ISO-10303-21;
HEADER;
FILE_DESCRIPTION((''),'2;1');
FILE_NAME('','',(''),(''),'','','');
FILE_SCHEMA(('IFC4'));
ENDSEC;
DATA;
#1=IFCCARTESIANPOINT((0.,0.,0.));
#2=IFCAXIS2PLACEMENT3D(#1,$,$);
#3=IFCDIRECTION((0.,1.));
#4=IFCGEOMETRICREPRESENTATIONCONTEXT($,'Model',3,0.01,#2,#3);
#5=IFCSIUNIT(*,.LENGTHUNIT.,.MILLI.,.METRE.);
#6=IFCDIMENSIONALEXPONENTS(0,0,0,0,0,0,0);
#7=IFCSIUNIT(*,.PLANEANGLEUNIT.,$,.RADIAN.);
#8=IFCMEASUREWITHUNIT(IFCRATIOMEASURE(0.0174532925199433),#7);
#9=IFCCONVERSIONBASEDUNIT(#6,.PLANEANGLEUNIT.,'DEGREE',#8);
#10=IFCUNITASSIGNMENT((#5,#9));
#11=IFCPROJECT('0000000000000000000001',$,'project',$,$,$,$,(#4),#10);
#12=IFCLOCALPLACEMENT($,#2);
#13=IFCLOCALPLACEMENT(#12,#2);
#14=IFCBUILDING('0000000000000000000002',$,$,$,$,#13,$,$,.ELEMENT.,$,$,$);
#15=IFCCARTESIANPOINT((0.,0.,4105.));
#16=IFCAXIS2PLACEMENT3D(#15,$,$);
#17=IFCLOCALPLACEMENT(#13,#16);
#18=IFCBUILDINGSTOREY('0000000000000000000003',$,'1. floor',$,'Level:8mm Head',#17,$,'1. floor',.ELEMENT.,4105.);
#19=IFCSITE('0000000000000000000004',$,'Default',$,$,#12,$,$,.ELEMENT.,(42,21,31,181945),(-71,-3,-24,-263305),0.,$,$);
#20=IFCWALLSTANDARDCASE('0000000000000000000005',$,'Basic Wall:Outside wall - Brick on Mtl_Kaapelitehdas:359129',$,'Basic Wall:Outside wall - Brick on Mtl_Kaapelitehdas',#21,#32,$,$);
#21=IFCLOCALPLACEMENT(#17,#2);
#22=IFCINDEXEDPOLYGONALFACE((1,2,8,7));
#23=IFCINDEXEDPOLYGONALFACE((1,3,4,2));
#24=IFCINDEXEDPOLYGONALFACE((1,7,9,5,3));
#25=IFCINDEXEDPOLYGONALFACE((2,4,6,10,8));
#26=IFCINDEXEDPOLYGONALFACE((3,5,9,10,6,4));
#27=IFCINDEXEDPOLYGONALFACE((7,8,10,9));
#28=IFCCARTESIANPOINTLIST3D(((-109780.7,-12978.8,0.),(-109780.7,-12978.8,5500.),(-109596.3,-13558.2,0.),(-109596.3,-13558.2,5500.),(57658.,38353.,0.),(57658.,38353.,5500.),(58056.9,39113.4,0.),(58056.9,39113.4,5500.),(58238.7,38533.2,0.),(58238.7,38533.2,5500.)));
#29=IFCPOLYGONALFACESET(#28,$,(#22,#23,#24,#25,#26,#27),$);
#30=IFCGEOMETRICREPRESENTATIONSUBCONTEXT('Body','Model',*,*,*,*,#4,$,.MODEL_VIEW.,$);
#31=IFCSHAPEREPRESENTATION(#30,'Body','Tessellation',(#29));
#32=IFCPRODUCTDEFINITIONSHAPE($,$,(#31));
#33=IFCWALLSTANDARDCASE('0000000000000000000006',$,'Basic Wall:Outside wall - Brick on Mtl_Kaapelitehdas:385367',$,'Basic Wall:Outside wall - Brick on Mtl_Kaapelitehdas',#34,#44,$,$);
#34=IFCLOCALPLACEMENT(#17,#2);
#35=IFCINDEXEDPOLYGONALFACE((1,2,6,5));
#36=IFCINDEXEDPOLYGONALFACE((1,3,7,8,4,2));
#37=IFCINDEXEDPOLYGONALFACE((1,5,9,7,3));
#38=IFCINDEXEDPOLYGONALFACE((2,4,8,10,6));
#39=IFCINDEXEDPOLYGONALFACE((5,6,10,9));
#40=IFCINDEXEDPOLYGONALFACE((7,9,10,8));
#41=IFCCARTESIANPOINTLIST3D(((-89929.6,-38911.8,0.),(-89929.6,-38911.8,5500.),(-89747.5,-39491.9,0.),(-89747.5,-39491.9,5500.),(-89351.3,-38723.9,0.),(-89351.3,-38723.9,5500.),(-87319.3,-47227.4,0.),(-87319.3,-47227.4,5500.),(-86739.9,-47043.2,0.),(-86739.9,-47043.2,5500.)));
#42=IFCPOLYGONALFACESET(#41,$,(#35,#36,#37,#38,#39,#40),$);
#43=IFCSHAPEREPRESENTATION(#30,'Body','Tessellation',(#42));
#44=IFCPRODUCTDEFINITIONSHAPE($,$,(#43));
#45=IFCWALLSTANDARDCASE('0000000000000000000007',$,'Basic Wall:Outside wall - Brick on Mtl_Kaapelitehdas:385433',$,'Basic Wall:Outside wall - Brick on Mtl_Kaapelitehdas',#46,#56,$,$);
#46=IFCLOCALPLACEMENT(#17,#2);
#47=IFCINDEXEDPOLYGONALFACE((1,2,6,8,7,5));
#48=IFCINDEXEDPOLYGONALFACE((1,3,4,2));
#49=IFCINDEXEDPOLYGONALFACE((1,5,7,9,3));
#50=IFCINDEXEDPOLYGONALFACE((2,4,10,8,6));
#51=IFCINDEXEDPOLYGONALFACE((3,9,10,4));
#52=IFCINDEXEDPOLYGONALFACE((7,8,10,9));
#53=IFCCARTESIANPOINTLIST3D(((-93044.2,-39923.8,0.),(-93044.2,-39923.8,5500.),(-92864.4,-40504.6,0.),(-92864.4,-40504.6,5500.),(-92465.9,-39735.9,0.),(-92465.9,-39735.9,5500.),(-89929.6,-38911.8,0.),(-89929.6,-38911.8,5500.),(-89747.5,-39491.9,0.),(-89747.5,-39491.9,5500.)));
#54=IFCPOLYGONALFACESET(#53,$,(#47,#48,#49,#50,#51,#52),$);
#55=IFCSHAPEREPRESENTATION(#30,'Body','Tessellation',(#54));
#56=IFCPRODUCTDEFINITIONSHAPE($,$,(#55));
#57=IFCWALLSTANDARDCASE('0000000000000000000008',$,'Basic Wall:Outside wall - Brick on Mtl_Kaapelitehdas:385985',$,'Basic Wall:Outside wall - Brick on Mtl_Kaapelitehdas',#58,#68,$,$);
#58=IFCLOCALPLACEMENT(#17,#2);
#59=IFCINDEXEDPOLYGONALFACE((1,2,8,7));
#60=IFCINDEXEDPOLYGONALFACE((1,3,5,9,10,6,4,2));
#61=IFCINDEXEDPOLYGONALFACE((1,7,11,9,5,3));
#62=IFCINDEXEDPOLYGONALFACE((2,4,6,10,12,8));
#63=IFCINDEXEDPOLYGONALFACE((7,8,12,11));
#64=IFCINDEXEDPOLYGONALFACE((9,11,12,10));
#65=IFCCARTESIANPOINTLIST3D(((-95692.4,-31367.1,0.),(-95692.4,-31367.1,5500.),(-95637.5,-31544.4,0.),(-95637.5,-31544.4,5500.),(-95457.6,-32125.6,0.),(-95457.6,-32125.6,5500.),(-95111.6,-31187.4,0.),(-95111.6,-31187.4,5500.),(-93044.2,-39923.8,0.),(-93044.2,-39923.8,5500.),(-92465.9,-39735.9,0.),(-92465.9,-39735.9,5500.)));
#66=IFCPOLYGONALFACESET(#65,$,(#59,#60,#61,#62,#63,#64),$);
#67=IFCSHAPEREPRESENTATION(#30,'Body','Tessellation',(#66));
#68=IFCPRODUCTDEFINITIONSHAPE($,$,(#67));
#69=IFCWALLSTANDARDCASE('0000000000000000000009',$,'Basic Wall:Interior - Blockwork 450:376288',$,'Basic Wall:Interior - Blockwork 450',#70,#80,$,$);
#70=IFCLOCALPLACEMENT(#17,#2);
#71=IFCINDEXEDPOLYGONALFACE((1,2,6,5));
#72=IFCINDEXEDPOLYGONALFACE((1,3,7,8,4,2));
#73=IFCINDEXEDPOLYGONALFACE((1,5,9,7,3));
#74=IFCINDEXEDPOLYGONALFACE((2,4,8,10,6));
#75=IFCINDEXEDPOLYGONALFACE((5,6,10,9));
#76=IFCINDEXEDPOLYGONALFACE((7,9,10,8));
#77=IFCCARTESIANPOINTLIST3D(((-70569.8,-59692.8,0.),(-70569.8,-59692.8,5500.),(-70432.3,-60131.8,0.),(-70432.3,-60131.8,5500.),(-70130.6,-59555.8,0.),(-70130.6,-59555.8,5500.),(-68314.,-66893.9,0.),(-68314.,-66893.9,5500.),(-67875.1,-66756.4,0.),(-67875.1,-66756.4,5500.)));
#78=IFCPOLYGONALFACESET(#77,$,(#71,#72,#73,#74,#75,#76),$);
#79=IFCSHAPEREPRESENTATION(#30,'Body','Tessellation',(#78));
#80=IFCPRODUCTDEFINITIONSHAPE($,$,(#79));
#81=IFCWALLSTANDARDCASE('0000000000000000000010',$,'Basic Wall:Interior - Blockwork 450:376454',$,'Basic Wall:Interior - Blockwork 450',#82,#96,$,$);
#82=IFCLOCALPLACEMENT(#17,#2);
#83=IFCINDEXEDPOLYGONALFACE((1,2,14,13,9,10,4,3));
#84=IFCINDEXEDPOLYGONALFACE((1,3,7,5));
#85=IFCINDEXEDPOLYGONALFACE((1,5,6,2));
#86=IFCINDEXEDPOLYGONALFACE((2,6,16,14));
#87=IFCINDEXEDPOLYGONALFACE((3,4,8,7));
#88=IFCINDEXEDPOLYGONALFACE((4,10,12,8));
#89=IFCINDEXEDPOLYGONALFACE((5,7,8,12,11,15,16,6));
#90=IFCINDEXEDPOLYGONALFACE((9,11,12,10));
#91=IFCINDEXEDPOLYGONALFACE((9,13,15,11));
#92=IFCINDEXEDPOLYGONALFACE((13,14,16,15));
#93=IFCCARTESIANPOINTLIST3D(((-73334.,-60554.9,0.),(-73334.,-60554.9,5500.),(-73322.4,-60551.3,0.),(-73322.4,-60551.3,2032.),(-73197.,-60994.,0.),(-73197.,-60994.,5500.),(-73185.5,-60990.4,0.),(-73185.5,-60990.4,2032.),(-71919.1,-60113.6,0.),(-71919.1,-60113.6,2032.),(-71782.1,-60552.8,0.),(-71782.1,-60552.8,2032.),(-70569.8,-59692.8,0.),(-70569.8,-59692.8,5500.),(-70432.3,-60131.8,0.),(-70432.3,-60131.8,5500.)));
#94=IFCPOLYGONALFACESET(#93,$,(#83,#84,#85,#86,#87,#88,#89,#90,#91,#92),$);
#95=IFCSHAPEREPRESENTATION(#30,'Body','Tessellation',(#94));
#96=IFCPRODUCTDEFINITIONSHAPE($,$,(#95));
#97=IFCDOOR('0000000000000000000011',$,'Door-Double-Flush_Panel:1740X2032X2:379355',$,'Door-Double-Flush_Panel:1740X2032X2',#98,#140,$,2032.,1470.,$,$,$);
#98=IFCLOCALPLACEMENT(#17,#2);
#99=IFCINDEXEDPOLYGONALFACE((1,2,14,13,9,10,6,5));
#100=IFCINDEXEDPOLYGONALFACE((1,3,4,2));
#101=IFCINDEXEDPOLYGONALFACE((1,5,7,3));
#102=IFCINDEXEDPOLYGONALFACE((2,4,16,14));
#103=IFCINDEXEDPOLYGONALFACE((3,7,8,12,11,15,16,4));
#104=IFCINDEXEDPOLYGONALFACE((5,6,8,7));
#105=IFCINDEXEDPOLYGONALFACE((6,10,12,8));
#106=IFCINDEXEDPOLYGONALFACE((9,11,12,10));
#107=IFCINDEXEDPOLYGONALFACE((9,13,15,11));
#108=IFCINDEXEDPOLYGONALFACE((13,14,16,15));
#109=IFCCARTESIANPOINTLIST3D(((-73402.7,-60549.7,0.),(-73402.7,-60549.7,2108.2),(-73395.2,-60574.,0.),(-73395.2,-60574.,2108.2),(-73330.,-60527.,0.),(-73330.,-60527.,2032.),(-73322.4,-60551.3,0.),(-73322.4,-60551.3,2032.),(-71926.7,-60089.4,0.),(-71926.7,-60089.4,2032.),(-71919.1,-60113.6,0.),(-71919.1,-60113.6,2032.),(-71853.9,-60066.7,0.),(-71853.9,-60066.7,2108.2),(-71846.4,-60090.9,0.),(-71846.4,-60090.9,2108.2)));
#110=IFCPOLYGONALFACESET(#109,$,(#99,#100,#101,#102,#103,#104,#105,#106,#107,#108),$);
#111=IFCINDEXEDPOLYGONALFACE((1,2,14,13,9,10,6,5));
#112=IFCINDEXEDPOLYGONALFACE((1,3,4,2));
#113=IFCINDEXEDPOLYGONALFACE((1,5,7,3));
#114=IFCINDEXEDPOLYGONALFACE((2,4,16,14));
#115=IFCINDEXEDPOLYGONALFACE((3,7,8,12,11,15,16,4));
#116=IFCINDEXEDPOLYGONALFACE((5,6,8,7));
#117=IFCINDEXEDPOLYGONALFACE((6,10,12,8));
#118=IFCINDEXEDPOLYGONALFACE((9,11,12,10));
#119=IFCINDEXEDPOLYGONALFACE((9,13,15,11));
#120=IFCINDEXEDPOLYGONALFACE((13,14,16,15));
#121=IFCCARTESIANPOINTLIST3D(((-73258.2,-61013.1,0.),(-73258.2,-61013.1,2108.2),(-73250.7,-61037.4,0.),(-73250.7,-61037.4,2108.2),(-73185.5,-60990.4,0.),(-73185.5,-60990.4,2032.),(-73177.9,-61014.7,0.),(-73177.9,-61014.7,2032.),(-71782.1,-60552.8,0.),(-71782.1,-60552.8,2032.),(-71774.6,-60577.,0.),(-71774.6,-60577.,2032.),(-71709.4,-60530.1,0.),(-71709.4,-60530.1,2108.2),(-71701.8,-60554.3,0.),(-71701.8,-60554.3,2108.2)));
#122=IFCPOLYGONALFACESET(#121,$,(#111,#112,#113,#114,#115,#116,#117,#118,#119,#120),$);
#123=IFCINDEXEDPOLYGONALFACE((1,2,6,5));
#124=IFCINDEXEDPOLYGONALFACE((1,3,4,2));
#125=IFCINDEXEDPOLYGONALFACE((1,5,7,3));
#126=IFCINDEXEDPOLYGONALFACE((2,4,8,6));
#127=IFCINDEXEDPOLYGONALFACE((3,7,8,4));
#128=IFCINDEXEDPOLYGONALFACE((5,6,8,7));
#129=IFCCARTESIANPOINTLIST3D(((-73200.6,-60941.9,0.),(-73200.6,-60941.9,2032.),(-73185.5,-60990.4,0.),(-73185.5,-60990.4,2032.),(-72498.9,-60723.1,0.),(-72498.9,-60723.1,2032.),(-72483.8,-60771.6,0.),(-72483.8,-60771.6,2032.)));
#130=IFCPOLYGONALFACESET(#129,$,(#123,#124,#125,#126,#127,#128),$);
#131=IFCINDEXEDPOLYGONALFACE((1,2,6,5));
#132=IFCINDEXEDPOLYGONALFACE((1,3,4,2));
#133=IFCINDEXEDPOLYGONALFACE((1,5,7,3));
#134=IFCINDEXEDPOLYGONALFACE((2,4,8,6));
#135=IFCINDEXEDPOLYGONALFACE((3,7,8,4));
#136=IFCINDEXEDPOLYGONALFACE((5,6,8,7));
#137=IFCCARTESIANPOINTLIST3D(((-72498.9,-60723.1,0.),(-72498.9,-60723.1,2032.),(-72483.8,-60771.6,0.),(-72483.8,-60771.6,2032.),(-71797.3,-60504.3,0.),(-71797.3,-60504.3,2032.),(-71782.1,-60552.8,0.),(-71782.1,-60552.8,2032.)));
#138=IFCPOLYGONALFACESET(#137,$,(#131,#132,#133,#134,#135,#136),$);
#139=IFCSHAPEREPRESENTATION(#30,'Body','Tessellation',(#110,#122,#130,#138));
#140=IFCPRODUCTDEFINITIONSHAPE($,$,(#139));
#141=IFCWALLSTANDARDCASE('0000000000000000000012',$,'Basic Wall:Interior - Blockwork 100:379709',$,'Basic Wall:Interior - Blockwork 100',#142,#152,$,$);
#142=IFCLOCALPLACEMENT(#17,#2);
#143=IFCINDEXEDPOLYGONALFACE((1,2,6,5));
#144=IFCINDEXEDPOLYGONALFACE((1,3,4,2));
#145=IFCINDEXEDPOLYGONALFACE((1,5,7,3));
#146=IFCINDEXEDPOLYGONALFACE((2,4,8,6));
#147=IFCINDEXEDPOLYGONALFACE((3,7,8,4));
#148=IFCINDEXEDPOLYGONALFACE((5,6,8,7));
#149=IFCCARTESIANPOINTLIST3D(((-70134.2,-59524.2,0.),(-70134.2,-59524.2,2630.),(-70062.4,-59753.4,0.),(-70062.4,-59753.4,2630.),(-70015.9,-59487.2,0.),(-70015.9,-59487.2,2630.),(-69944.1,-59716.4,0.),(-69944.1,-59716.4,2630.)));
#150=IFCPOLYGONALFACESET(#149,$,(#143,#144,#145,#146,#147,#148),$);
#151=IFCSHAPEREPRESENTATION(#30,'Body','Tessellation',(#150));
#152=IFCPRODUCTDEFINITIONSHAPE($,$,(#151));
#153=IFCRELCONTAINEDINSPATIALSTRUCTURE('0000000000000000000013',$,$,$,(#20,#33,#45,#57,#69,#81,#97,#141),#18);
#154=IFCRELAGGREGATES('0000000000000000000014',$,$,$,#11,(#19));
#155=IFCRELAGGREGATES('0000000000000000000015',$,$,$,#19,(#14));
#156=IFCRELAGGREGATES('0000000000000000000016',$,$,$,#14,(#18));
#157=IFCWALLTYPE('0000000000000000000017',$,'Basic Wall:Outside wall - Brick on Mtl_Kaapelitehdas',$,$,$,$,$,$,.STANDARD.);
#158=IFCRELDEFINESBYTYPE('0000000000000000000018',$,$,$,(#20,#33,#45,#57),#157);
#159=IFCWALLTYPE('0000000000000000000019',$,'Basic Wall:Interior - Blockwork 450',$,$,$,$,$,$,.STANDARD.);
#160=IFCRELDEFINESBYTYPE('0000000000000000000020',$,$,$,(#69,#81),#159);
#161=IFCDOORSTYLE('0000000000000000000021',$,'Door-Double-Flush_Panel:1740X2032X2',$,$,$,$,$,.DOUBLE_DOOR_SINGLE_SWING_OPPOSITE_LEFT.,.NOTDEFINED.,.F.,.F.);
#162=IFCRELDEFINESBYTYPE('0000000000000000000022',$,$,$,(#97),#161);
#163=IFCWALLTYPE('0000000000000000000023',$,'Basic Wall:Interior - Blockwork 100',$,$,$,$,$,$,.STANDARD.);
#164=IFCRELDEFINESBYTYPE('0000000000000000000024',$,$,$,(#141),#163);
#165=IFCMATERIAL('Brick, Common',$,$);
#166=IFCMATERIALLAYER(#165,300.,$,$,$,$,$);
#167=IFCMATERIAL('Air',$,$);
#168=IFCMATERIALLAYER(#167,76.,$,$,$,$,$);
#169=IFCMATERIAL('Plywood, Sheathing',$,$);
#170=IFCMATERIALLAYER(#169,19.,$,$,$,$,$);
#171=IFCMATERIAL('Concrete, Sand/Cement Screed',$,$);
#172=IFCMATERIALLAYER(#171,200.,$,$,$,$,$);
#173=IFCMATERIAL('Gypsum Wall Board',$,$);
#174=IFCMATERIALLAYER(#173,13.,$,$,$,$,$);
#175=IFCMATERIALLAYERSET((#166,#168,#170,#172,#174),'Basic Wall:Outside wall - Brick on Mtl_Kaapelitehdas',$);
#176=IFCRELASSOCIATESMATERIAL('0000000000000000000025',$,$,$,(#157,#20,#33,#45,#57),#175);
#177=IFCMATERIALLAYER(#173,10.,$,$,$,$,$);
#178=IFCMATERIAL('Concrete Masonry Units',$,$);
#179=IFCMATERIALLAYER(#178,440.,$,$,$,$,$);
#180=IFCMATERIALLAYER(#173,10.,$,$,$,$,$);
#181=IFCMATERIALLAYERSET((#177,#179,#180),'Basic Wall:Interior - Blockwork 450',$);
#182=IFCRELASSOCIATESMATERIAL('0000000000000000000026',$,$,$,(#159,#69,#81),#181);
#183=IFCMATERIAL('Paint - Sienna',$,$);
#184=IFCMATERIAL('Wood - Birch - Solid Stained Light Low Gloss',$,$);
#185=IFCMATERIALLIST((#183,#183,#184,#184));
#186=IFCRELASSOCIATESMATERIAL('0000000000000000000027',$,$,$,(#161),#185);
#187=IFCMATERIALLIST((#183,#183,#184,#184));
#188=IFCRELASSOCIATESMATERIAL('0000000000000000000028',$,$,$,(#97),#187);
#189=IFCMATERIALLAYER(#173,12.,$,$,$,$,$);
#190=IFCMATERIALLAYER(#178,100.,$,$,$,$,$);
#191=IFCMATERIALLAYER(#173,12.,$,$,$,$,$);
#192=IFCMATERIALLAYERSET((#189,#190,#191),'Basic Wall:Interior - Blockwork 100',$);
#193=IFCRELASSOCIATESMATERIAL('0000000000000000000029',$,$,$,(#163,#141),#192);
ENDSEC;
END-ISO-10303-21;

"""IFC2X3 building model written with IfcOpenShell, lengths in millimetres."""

from ifc_helpers import new_model, entity, si_unit, converted_unit, direction, frame, frame_2d, origin, place, context, subcontext, project, spatial, polyline, rectangle, outline, extrude, source, transform, mapped, material, material_list, layer, layer_set, layer_usage, type_object, type_shapes, element, fill, save


model = new_model("IFC2X3")

# Units and contexts
model_context = context("Model", 3, precision=0.01, world=origin(), true_north=direction((0.0, 1.0)))
body_context = subcontext(model_context, "Body", "Model", "MODEL_VIEW")
ifc_project = project(units=[si_unit("LENGTHUNIT", "METRE", prefix="MILLI"), converted_unit("PLANEANGLEUNIT", "DEGREE", entity("IfcRatioMeasure", 0.0174532925199433), si_unit("PLANEANGLEUNIT", "RADIAN"), dimensions=[0, 0, 0, 0, 0, 0, 0])], contexts=[model_context])

# Site, building, storey
site_placement = place(None, origin())
site = spatial("IfcSite", under=ifc_project, at=site_placement, Name="Default", CompositionType="ELEMENT", RefLatitude=(42, 21, 31, 181945), RefLongitude=(-71, -3, -24, -263305), RefElevation=0.0)
building_placement = place(site_placement, origin())
building = spatial("IfcBuilding", under=site, at=building_placement, CompositionType="ELEMENT")
storey_placement = place(building_placement, frame((0.0, 0.0, 4105.0)))
storey = spatial("IfcBuildingStorey", under=building, at=storey_placement, Name="1. floor", ObjectType="Level:8mm Head", LongName="1. floor", CompositionType="ELEMENT", Elevation=4105.0)

# Walls
ifc_material_1 = material(Name="Brick, Common")
ifc_layer_1 = layer(ifc_material_1, 300.0)
ifc_material_2 = material(Name="Air")
ifc_layer_2 = layer(ifc_material_2, 76.0)
ifc_material_3 = material(Name="Plywood, Sheathing")
ifc_layer_3 = layer(ifc_material_3, 19.0)
ifc_material_4 = material(Name="Concrete, Sand/Cement Screed")
ifc_layer_4 = layer(ifc_material_4, 200.0)
ifc_material_5 = material(Name="Gypsum Wall Board")
ifc_layer_5 = layer(ifc_material_5, 13.0)
ifc_layer_set_1 = layer_set([ifc_layer_1, ifc_layer_2, ifc_layer_3, ifc_layer_4, ifc_layer_5], Name="Basic Wall:Outside wall - Brick on Mtl_Kaapelitehdas")
wall_type_1 = type_object("IfcWallType", Name="Basic Wall:Outside wall - Brick on Mtl_Kaapelitehdas", PredefinedType="STANDARD", material=ifc_layer_set_1)
ifc_layer_usage_1 = layer_usage(ifc_layer_set_1, "AXIS2", "NEGATIVE", 304.0)
wall_1_placement = place(storey_placement, frame((-109690.6, -13269.2, 0.0), z_axis=(0.0, 0.0, 1.0), x_axis=(0.955057, 0.296424, 0.0)))
element("IfcWallStandardCase", 1, at=wall_1_placement, inside=storey, type_object=wall_type_1, material=ifc_layer_usage_1, Name="Basic Wall:Outside wall - Brick on Mtl_Kaapelitehdas:359129", ObjectType="Basic Wall:Outside wall - Brick on Mtl_Kaapelitehdas", context=body_context, shape_type="SweptSolid", body=[
    extrude(outline(polyline([(175737.4, -304.0), (175735.8, 304.0), (0.0, 304.0), (4.3, -304.0), (175129.4, -304.0), (175737.4, -304.0)])), origin(), (0.0, 0.0, 1.0), 5500.0),
])
ifc_layer_usage_2 = layer_usage(ifc_layer_set_1, "AXIS2", "NEGATIVE", 304.0)
wall_2_placement = place(storey_placement, frame((-87029.3, -47136.3, 0.0), z_axis=(0.0, 0.0, 1.0), x_axis=(-0.299495, 0.954098, 0.0)))
element("IfcWallStandardCase", 2, at=wall_2_placement, inside=storey, type_object=wall_type_1, material=ifc_layer_usage_2, Name="Basic Wall:Outside wall - Brick on Mtl_Kaapelitehdas:385367", ObjectType="Basic Wall:Outside wall - Brick on Mtl_Kaapelitehdas", context=body_context, shape_type="SweptSolid", body=[
    extrude(outline(polyline([(8721.8, -304.0), (8715.7, 304.0), (8107.6, 304.0), (0.0, 304.0), (2.2, -304.0), (8721.8, -304.0)])), origin(), (0.0, 0.0, 1.0), 5500.0),
])
ifc_layer_usage_3 = layer_usage(ifc_layer_set_1, "AXIS2", "NEGATIVE", 304.0)
wall_3_placement = place(storey_placement, frame((-89835.7, -39200.9, 0.0), z_axis=(0.0, 0.0, 1.0), x_axis=(-0.951057, -0.309017, 0.0)))
element("IfcWallStandardCase", 3, at=wall_3_placement, inside=storey, type_object=wall_type_1, material=ifc_layer_usage_3, Name="Basic Wall:Outside wall - Brick on Mtl_Kaapelitehdas:385433", ObjectType="Basic Wall:Outside wall - Brick on Mtl_Kaapelitehdas", context=body_context, shape_type="SweptSolid", body=[
    extrude(outline(polyline([(3274.9, -304.0), (3283.4, 304.0), (6.1, 304.0), (0.0, -304.0), (2666.8, -304.0), (3274.9, -304.0)])), origin(), (0.0, 0.0, 1.0), 5500.0),
])
ifc_layer_usage_4 = layer_usage(ifc_layer_set_1, "AXIS2", "NEGATIVE", 304.0)
wall_4_placement = place(storey_placement, frame((-92753.8, -39833.9, 0.0), z_axis=(0.0, 0.0, 1.0), x_axis=(-0.295652, 0.955296, 0.0)))
element("IfcWallStandardCase", 4, at=wall_4_placement, inside=storey, type_object=wall_type_1, material=ifc_layer_usage_4, Name="Basic Wall:Outside wall - Brick on Mtl_Kaapelitehdas:385985", ObjectType="Basic Wall:Outside wall - Brick on Mtl_Kaapelitehdas", context=body_context, shape_type="SweptSolid", body=[
    extrude(outline(polyline([(8957.0, -304.0), (8957.0, 304.0), (8771.5, 304.0), (8163.0, 304.0), (0.0, 304.0), (8.5, -304.0), (8957.0, -304.0)])), origin(), (0.0, 0.0, 1.0), 5500.0),
])
ifc_layer_6 = layer(ifc_material_5, 10.0)
ifc_material_6 = material(Name="Concrete Masonry Units")
ifc_layer_7 = layer(ifc_material_6, 440.0)
ifc_layer_8 = layer(ifc_material_5, 10.0)
ifc_layer_set_2 = layer_set([ifc_layer_6, ifc_layer_7, ifc_layer_8], Name="Basic Wall:Interior - Blockwork 450")
ifc_layer_usage_5 = layer_usage(ifc_layer_set_2, "AXIS2", "NEGATIVE", 230.0)
wall_type_2 = type_object("IfcWallType", Name="Basic Wall:Interior - Blockwork 450", PredefinedType="STANDARD", material=ifc_layer_set_2)
wall_5_placement = place(storey_placement, frame((-70350.3, -59624.0, 0.0), z_axis=(0.0, 0.0, 1.0), x_axis=(0.298924, -0.954277, 0.0)))
element("IfcWallStandardCase", 5, at=wall_5_placement, inside=storey, type_object=wall_type_2, material=ifc_layer_usage_5, Name="Basic Wall:Interior - Blockwork 450:376288", ObjectType="Basic Wall:Interior - Blockwork 450", context=body_context, shape_type="SweptSolid", body=[
    extrude(outline(polyline([(7546.2, -230.0), (7546.2, 230.0), (0.6, 230.0), (0.0, -230.0), (460.0, -230.0), (7546.2, -230.0)])), origin(), (0.0, 0.0, 1.0), 5500.0),
])

# Wall, opening, door
ifc_layer_usage_6 = layer_usage(ifc_layer_set_2, "AXIS2", "NEGATIVE", 230.0)
wall_6_placement = place(storey_placement, frame((-70500.7, -59912.2, 0.0), z_axis=(0.0, 0.0, 1.0), x_axis=(-0.954648, -0.297735, 0.0)))
wall_6 = element("IfcWallStandardCase", 6, at=wall_6_placement, inside=storey, type_object=wall_type_2, material=ifc_layer_usage_6, Name="Basic Wall:Interior - Blockwork 450:376454", ObjectType="Basic Wall:Interior - Blockwork 450", context=body_context, shape_type="SweptSolid", body=[
    extrude(outline(polyline([(0.6, -230.0), (2896.1, -230.0), (2896.1, 230.0), (0.0, 230.0), (0.6, -230.0)])), origin(), (0.0, 0.0, 1.0), 5500.0),
])
opening_placement = place(wall_6_placement, frame((1414.0, -230.0, 0.0)))
opening = element("IfcOpeningElement", 7, at=opening_placement, cuts=wall_6, ObjectType="Opening", context=body_context, shape_type="SweptSolid", body=[
    extrude(rectangle(XDim=2032.0, YDim=1470.0, at=frame_2d((1016.0, 735.0), x_axis=(1.0, 0.0))), frame((0.0, 0.0, 0.0), z_axis=(0.0, 1.0, 0.0), x_axis=(0.0, 0.0, 1.0)), (0.0, 0.0, 1.0), 460.0),
])
ifc_material_7 = material(Name="Paint - Sienna")
ifc_material_8 = material(Name="Wood - Birch - Solid Stained Light Low Gloss")
ifc_material_list_1 = material_list([ifc_material_7, ifc_material_7, ifc_material_8, ifc_material_8])
ifc_material_list_2 = material_list([ifc_material_7, ifc_material_7, ifc_material_8, ifc_material_8])
door_style = type_object("IfcDoorStyle", Name="Door-Double-Flush_Panel:1740X2032X2", ConstructionType="NOTDEFINED", OperationType="DOUBLE_DOOR_SINGLE_SWING_OPPOSITE_LEFT", ParameterTakesPrecedence=False, Sizeable=False, material=ifc_material_list_2)
shared_shape = source(origin(), body_context, "Body", "SweptSolid", [
    extrude(outline(polyline([(-997.0, 735.0), (1035.0, 735.0), (1035.0, 811.2), (-1073.2, 811.2), (-1073.2, -811.2), (1035.0, -811.2), (1035.0, -735.0), (-997.0, -735.0), (-997.0, 735.0)])), frame((735.0, -25.4, 1035.0), z_axis=(0.0, 1.0, 0.0), x_axis=(0.0, 0.0, -1.0)), (0.0, 0.0, 1.0), 25.4),
    extrude(outline(polyline([(-997.0, 735.0), (1035.0, 735.0), (1035.0, 811.2), (-1073.2, 811.2), (-1073.2, -811.2), (1035.0, -811.2), (1035.0, -735.0), (-997.0, -735.0), (-997.0, 735.0)])), frame((735.0, 460.0, 1035.0), z_axis=(0.0, 1.0, 0.0), x_axis=(0.0, 0.0, -1.0)), (0.0, 0.0, 1.0), 25.4),
    extrude(rectangle(XDim=50.8, YDim=735.0, at=frame_2d((0.0, 0.0), x_axis=(1.0, 0.0))), frame((1102.5, 434.6, 0.0), z_axis=(0.0, 0.0, 1.0), x_axis=(0.0, -1.0, 0.0)), (0.0, 0.0, 1.0), 2032.0),
    extrude(rectangle(XDim=50.8, YDim=735.0, at=frame_2d((0.0, 0.0), x_axis=(1.0, 0.0))), frame((367.5, 434.6, 0.0), z_axis=(0.0, 0.0, 1.0), x_axis=(0.0, -1.0, 0.0)), (0.0, 0.0, 1.0), 2032.0),
])
type_shapes(door_style, [shared_shape])
door_placement = place(opening_placement, origin())
door = element("IfcDoor", 8, at=door_placement, inside=storey, type_object=door_style, material=ifc_material_list_1, Name="Door-Double-Flush_Panel:1740X2032X2:379355", ObjectType="Door-Double-Flush_Panel:1740X2032X2", OverallHeight=2032.0, OverallWidth=1470.0, context=body_context, shape_type="MappedRepresentation", body=[
    mapped(shared_shape, transform((0.0, 0.0, 0.0), scale=1.0)),
])
fill(opening, door)

# Wall
ifc_layer_9 = layer(ifc_material_5, 12.0)
ifc_layer_10 = layer(ifc_material_6, 100.0)
ifc_layer_11 = layer(ifc_material_5, 12.0)
ifc_layer_set_3 = layer_set([ifc_layer_9, ifc_layer_10, ifc_layer_11], Name="Basic Wall:Interior - Blockwork 100")
ifc_layer_usage_7 = layer_usage(ifc_layer_set_3, "AXIS2", "NEGATIVE", 62.0)
wall_type_3 = type_object("IfcWallType", Name="Basic Wall:Interior - Blockwork 100", PredefinedType="STANDARD", material=ifc_layer_set_3)
wall_7_placement = place(storey_placement, frame((-70075.1, -59505.7, 0.0), z_axis=(0.0, 0.0, 1.0), x_axis=(0.298924, -0.954277, 0.0)))
element("IfcWallStandardCase", 9, at=wall_7_placement, inside=storey, type_object=wall_type_3, material=ifc_layer_usage_7, Name="Basic Wall:Interior - Blockwork 100:379709", ObjectType="Basic Wall:Interior - Blockwork 100", context=body_context, shape_type="SweptSolid", body=[
    extrude(rectangle(XDim=240.2, YDim=124.0, at=frame_2d((120.1, 0.0), x_axis=(-1.0, 0.0))), origin(), (0.0, 0.0, 1.0), 2630.0),
])

save(model, "model.ifc")
